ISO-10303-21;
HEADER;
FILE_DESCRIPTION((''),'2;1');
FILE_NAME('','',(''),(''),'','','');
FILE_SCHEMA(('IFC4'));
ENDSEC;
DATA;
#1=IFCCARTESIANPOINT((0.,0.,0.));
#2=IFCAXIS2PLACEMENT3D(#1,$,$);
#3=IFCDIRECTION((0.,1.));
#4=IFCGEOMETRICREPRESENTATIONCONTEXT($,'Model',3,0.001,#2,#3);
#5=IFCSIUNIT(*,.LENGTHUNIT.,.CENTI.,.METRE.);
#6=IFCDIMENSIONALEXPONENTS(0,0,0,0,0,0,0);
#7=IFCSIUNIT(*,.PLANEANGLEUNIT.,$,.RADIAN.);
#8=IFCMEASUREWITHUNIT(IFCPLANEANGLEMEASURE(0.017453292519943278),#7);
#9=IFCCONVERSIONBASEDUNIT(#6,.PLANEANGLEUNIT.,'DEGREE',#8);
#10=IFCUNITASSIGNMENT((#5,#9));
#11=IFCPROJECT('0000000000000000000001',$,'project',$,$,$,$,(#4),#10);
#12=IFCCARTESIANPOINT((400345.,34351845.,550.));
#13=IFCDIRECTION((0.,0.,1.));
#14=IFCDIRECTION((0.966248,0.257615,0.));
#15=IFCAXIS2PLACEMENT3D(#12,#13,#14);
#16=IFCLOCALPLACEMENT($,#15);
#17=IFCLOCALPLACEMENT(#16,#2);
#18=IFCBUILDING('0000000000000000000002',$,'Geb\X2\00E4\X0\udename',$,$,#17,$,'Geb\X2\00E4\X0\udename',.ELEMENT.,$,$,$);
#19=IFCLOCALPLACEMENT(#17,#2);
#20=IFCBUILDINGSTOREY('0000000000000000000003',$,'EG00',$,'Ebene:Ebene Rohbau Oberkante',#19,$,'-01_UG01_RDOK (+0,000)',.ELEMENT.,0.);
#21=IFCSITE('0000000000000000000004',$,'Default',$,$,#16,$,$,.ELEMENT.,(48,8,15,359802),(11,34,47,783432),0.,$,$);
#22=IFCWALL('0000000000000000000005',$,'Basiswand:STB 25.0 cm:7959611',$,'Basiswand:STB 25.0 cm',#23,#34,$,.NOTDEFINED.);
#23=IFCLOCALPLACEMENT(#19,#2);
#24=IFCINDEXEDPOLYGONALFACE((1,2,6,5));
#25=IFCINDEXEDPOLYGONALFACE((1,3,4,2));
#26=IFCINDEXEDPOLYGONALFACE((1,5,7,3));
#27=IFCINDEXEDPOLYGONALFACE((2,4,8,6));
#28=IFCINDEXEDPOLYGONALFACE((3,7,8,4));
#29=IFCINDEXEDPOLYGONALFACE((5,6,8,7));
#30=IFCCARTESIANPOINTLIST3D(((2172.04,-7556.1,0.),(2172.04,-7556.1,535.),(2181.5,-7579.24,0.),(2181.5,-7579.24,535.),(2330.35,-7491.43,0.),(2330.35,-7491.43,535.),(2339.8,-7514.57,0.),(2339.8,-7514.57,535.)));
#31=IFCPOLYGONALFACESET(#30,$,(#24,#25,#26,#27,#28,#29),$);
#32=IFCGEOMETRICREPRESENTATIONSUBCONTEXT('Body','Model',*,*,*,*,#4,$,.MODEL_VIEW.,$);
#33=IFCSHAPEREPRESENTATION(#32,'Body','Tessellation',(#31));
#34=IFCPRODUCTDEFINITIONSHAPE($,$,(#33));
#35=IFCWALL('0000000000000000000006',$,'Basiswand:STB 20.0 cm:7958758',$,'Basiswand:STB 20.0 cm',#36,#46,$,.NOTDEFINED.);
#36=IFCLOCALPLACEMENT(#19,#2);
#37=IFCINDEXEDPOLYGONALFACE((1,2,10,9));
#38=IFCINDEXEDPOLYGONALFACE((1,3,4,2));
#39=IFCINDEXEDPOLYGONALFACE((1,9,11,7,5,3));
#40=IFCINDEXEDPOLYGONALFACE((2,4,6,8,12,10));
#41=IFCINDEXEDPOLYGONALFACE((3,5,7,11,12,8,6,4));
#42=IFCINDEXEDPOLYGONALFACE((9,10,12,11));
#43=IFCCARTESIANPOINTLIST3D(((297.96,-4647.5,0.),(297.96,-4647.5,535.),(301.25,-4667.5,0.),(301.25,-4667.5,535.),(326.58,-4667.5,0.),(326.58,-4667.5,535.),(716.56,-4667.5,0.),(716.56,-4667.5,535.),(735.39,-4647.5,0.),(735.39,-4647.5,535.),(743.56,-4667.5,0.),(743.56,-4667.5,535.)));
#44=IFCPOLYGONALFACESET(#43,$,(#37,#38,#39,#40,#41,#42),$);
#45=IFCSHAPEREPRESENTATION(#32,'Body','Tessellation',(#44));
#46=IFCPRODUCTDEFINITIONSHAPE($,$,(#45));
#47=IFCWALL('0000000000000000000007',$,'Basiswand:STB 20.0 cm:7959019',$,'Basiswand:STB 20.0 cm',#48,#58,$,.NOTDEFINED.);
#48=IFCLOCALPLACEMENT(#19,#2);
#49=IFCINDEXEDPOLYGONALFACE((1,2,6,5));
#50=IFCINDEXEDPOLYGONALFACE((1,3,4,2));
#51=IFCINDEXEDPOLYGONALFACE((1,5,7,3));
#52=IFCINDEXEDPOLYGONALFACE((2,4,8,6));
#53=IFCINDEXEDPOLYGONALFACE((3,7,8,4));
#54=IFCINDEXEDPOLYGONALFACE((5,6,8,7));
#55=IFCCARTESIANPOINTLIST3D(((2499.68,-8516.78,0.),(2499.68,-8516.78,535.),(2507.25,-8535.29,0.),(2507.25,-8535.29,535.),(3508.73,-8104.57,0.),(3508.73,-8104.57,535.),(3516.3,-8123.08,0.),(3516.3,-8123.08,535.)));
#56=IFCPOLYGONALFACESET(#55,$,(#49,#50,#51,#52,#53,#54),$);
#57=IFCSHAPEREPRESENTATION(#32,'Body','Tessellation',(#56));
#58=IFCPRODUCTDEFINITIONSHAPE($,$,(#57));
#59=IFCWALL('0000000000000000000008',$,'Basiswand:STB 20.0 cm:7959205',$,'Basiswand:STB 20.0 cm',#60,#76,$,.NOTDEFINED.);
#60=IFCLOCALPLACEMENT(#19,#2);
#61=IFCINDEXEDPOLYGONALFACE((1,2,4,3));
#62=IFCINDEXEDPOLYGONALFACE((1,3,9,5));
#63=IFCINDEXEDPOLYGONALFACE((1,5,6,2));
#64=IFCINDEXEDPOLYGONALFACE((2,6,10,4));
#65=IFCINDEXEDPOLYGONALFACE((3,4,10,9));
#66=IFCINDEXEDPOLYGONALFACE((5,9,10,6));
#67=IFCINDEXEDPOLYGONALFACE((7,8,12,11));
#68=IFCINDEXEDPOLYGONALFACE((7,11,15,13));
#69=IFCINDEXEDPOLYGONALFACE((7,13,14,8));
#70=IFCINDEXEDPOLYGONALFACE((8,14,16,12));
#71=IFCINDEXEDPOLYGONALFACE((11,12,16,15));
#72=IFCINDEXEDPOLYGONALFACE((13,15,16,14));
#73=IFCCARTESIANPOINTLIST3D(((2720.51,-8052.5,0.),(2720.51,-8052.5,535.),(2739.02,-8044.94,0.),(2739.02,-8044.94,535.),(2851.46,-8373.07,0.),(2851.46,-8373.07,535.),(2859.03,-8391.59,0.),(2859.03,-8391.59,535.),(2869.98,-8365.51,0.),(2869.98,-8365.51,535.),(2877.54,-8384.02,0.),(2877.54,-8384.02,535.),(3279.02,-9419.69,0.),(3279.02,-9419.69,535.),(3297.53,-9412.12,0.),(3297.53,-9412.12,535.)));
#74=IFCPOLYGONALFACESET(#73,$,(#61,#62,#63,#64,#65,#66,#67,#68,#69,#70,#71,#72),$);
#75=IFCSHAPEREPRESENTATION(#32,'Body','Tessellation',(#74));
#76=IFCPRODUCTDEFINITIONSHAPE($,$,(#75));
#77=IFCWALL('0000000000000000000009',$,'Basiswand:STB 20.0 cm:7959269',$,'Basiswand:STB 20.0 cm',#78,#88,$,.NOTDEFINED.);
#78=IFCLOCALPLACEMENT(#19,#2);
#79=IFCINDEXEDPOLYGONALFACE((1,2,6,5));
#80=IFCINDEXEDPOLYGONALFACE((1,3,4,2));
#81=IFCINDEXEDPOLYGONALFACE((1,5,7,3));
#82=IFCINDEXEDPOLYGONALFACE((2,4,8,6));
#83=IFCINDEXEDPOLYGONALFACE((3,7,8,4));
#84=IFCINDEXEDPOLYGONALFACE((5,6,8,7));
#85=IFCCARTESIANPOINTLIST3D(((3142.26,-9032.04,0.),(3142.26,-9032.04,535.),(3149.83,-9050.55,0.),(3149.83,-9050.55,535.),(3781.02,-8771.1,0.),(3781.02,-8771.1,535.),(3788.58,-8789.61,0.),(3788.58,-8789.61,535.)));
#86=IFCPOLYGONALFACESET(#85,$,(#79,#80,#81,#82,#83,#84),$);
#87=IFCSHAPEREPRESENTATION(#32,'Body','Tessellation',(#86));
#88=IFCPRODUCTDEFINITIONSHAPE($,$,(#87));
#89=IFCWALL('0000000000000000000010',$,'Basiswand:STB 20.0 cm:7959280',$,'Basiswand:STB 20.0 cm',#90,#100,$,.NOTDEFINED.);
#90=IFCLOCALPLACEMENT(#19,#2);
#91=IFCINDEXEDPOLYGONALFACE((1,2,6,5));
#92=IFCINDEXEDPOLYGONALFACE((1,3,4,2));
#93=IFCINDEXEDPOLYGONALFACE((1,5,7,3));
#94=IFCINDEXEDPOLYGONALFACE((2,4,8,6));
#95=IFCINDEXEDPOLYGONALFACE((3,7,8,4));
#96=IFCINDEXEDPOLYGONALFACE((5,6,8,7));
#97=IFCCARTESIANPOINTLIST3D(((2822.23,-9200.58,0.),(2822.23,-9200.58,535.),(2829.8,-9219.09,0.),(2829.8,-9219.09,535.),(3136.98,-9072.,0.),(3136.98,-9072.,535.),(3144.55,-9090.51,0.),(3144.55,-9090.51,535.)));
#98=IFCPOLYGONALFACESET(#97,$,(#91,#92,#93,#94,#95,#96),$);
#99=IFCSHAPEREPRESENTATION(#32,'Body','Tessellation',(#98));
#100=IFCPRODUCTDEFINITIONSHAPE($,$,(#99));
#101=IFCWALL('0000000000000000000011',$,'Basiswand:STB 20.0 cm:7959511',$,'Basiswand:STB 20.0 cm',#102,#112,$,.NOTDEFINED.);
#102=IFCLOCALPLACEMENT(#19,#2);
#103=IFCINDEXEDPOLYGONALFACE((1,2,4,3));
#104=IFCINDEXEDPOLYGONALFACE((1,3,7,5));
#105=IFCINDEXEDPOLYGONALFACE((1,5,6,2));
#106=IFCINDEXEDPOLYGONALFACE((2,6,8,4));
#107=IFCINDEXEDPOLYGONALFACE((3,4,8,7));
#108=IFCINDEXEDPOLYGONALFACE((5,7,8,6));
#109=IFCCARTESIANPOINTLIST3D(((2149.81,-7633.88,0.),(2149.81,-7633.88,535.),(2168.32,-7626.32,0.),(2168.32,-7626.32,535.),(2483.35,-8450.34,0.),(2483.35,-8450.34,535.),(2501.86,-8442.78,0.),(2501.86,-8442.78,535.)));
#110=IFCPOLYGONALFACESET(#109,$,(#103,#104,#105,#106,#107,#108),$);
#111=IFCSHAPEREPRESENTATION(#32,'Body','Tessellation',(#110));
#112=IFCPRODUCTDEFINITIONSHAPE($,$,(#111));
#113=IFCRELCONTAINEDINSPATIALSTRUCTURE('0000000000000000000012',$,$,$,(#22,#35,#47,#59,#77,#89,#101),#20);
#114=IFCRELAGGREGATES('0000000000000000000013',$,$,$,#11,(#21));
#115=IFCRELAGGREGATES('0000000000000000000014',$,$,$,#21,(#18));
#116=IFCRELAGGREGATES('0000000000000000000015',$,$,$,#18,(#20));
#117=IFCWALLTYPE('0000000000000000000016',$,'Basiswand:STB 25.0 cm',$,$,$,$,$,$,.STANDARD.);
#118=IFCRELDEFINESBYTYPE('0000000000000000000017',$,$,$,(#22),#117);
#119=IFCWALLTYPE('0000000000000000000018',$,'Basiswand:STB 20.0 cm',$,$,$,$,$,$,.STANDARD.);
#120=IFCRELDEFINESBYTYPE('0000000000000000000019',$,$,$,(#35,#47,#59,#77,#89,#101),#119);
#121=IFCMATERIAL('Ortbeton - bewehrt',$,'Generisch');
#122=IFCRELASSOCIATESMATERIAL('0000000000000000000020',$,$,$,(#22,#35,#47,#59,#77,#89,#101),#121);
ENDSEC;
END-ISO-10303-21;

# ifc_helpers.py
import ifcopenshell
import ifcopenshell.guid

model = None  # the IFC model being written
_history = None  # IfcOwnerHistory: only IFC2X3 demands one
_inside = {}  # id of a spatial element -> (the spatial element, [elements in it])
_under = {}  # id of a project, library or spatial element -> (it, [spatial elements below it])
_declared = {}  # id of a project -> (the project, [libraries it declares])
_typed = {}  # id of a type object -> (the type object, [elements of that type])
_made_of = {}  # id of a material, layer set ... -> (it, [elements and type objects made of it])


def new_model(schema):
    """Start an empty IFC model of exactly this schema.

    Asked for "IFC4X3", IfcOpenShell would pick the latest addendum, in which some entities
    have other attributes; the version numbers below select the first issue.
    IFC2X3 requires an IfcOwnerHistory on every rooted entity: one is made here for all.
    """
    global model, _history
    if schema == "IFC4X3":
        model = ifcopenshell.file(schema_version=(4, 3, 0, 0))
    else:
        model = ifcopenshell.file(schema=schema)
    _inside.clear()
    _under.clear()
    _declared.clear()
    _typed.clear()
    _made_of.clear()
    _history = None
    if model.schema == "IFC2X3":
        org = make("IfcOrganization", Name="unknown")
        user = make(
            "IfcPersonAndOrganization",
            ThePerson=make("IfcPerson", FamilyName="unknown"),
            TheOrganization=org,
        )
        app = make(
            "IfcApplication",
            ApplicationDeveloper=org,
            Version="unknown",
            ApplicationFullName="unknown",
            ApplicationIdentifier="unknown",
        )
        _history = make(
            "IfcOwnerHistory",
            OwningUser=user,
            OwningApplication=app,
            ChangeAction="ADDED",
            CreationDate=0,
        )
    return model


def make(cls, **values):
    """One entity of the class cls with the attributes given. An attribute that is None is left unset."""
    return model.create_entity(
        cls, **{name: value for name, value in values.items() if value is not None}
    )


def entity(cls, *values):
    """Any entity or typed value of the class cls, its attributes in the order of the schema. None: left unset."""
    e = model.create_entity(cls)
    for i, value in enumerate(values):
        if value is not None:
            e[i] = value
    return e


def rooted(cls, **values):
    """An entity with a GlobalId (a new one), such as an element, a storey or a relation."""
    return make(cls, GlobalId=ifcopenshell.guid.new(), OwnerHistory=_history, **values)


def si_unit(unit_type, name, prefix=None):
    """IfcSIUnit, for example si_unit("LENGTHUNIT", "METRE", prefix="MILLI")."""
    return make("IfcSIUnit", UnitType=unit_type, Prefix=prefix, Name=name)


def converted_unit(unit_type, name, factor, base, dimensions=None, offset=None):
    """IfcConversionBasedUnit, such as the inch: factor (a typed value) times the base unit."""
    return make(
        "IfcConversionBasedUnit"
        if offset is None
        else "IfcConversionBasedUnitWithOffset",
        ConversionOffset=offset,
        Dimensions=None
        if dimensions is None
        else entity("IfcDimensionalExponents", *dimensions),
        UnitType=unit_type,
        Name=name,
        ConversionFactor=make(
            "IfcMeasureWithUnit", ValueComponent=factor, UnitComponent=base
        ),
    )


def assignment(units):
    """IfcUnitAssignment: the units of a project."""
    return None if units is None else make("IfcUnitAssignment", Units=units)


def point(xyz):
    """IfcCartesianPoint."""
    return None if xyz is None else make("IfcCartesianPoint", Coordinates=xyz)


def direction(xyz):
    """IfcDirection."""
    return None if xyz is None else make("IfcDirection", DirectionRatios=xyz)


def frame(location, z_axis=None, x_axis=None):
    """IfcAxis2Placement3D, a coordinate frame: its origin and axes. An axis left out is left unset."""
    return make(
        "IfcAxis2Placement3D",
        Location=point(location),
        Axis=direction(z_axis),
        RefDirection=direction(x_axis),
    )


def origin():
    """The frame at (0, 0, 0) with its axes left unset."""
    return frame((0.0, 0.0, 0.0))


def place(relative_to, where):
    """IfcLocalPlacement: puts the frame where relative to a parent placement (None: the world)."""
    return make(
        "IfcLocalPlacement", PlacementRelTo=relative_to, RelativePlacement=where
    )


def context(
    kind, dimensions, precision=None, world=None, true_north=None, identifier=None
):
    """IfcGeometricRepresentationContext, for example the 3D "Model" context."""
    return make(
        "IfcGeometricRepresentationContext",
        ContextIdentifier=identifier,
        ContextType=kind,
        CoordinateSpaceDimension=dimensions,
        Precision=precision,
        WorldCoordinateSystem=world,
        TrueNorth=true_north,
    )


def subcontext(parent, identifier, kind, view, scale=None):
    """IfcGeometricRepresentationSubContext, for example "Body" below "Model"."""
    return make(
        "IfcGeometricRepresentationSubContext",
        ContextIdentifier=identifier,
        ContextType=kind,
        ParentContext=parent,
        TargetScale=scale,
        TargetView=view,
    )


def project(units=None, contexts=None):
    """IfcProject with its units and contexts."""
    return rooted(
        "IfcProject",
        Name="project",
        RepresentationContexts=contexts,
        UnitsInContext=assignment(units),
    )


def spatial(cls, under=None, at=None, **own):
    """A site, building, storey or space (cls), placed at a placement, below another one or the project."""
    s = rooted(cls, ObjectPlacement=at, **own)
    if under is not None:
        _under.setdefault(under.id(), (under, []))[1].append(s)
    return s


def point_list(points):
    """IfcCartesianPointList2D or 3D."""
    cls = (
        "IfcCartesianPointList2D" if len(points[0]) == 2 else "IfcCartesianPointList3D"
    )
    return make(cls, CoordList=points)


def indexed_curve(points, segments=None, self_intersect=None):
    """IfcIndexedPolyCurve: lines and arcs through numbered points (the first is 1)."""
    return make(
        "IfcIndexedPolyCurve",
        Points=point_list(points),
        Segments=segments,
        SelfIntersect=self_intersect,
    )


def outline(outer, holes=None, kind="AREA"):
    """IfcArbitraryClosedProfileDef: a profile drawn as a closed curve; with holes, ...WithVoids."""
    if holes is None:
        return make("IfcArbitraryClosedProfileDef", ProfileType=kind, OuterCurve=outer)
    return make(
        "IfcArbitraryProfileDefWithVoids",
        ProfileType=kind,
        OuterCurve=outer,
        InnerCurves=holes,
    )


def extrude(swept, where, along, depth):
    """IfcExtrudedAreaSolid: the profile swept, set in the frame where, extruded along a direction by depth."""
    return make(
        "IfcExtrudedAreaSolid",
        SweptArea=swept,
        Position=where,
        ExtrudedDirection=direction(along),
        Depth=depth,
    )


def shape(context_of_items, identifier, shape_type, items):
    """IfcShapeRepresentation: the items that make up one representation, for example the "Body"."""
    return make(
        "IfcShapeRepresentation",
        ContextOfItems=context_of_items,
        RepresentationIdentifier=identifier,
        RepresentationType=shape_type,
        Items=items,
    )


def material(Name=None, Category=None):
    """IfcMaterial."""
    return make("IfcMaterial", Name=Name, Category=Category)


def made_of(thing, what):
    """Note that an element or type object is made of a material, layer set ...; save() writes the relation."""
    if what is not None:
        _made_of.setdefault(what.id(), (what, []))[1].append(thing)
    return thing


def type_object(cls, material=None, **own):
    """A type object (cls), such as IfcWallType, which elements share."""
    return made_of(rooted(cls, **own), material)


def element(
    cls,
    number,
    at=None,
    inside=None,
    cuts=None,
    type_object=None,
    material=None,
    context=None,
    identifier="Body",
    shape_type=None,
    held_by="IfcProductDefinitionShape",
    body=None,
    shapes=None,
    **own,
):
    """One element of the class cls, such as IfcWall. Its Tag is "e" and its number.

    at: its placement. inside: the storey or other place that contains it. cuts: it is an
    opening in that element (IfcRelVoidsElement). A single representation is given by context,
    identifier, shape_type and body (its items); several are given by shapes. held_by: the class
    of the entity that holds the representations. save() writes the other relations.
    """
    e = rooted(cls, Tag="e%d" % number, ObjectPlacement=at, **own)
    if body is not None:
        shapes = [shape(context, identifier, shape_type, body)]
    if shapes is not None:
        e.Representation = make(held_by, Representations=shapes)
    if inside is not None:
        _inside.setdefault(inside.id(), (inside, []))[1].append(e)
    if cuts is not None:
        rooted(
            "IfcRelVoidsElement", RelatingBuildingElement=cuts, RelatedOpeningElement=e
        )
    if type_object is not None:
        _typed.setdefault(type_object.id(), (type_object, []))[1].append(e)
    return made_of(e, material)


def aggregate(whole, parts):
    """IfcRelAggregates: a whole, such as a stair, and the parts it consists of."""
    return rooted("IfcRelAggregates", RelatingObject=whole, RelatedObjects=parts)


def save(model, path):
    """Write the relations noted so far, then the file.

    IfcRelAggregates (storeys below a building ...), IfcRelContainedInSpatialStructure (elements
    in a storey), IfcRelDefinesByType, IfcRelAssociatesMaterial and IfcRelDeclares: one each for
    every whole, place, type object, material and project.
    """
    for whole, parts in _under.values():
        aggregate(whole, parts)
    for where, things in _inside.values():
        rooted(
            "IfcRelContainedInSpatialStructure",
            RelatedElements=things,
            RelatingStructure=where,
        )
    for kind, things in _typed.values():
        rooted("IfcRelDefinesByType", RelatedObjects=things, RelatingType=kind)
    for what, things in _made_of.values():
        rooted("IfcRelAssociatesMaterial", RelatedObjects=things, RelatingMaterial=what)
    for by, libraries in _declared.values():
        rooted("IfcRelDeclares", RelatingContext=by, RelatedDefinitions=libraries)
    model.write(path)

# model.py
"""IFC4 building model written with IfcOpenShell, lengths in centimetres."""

from ifc_helpers import new_model, entity, si_unit, converted_unit, direction, frame, origin, place, context, subcontext, project, spatial, indexed_curve, outline, extrude, material, type_object, element, save


model = new_model("IFC4")

# Units and contexts
model_context = context("Model", 3, precision=0.001, world=origin(), true_north=direction((0.0, 1.0)))
body_context = subcontext(model_context, "Body", "Model", "MODEL_VIEW")
ifc_project = project(units=[si_unit("LENGTHUNIT", "METRE", prefix="CENTI"), converted_unit("PLANEANGLEUNIT", "DEGREE", entity("IfcPlaneAngleMeasure", 0.017453292519943278), si_unit("PLANEANGLEUNIT", "RADIAN"), dimensions=[0, 0, 0, 0, 0, 0, 0])], contexts=[model_context])

# Site, building, storey
site_placement = place(None, frame((400345.0, 34351845.0, 550.0), z_axis=(0.0, 0.0, 1.0), x_axis=(0.966248, 0.257615, 0.0)))
site = spatial("IfcSite", under=ifc_project, at=site_placement, Name="Default", CompositionType="ELEMENT", RefLatitude=(48, 8, 15, 359802), RefLongitude=(11, 34, 47, 783432), RefElevation=0.0)
building_placement = place(site_placement, origin())
building = spatial("IfcBuilding", under=site, at=building_placement, Name="Gebäudename", LongName="Gebäudename", CompositionType="ELEMENT")
storey_placement = place(building_placement, origin())
storey = spatial("IfcBuildingStorey", under=building, at=storey_placement, Name="EG00", ObjectType="Ebene:Ebene Rohbau Oberkante", LongName="-01_UG01_RDOK (+0,000)", CompositionType="ELEMENT", Elevation=0.0)

# Walls
ifc_material = material(Name="Ortbeton - bewehrt", Category="Generisch")
wall_type_1 = type_object("IfcWallType", Name="Basiswand:STB 25.0 cm", PredefinedType="STANDARD")
wall_1_placement = place(storey_placement, frame((2176.77, -7567.67, 0.0), z_axis=(0.0, 0.0, 1.0), x_axis=(0.925734, 0.378175, 0.0)))
element("IfcWall", 1, at=wall_1_placement, inside=storey, type_object=wall_type_1, material=ifc_material, Name="Basiswand:STB 25.0 cm:7959611", ObjectType="Basiswand:STB 25.0 cm", PredefinedType="NOTDEFINED", context=body_context, shape_type="SweptSolid", body=[
    extrude(outline(indexed_curve([(171.0, 12.5), (0.0, 12.5), (0.0, -12.5), (171.0, -12.5), (171.0, 12.5)], self_intersect=False)), origin(), (0.0, 0.0, 1.0), 535.0),
])
wall_type_2 = type_object("IfcWallType", Name="Basiswand:STB 20.0 cm", PredefinedType="STANDARD")
wall_2_placement = place(storey_placement, frame((743.56, -4657.5, 0.0), z_axis=(0.0, 0.0, 1.0), x_axis=(-1.0, 0.0, 0.0)))
element("IfcWall", 2, at=wall_2_placement, inside=storey, type_object=wall_type_2, material=ifc_material, Name="Basiswand:STB 20.0 cm:7958758", ObjectType="Basiswand:STB 20.0 cm", PredefinedType="NOTDEFINED", context=body_context, shape_type="SweptSolid", body=[
    extrude(outline(indexed_curve([(445.6, -10.0), (442.32, 10.0), (416.98, 10.0), (27.01, 10.0), (0.0, 10.0), (8.17, -10.0), (445.6, -10.0)], self_intersect=False)), origin(), (0.0, 0.0, 1.0), 535.0),
])
wall_3_placement = place(storey_placement, frame((2503.46, -8526.03, 0.0), z_axis=(0.0, 0.0, 1.0), x_axis=(0.925734, 0.378175, 0.0)))
element("IfcWall", 3, at=wall_3_placement, inside=storey, type_object=wall_type_2, material=ifc_material, Name="Basiswand:STB 20.0 cm:7959019", ObjectType="Basiswand:STB 20.0 cm", PredefinedType="NOTDEFINED", context=body_context, shape_type="SweptSolid", body=[
    extrude(outline(indexed_curve([(1090.0, 10.0), (0.0, 10.0), (0.0, -10.0), (1090.0, -10.0), (1090.0, 10.0)], self_intersect=False)), origin(), (0.0, 0.0, 1.0), 535.0),
])

# Wall, opening
wall_4_placement = place(storey_placement, frame((2729.76, -8048.72, 0.0), z_axis=(0.0, 0.0, 1.0), x_axis=(0.378175, -0.925734, 0.0)))
wall_4 = element("IfcWall", 4, at=wall_4_placement, inside=storey, type_object=wall_type_2, material=ifc_material, Name="Basiswand:STB 20.0 cm:7959205", ObjectType="Basiswand:STB 20.0 cm", PredefinedType="NOTDEFINED", context=body_context, shape_type="SweptSolid", body=[
    extrude(outline(indexed_curve([(1476.86, 10.0), (0.0, 10.0), (0.0, -10.0), (1476.86, -10.0), (1476.86, 10.0)], self_intersect=False)), origin(), (0.0, 0.0, 1.0), 535.0),
])
opening_placement = place(storey_placement, frame((2729.76, -8048.72, 0.0), z_axis=(0.0, 0.0, 1.0), x_axis=(0.378175, -0.925734, 0.0)))
element("IfcOpeningElement", 5, at=opening_placement, cuts=wall_4, PredefinedType="OPENING", context=body_context, shape_type="SweptSolid", body=[
    extrude(outline(indexed_curve([(-267.5, -10.0), (267.5, -10.0), (267.5, 10.0), (-267.5, 10.0), (-267.5, -10.0)], self_intersect=False)), frame((366.29, 0.0, 267.5), z_axis=(-1.0, 0.0, 0.0), x_axis=(0.0, 0.0, 1.0)), (0.0, 0.0, 1.0), 20.0),
])

# Walls
wall_5_placement = place(storey_placement, frame((3146.04, -9041.29, 0.0), z_axis=(0.0, 0.0, 1.0), x_axis=(0.925734, 0.378175, 0.0)))
element("IfcWall", 6, at=wall_5_placement, inside=storey, type_object=wall_type_2, material=ifc_material, Name="Basiswand:STB 20.0 cm:7959269", ObjectType="Basiswand:STB 20.0 cm", PredefinedType="NOTDEFINED", context=body_context, shape_type="SweptSolid", body=[
    extrude(outline(indexed_curve([(690.0, 10.0), (0.0, 10.0), (0.0, -10.0), (690.0, -10.0), (690.0, 10.0)], self_intersect=False)), origin(), (0.0, 0.0, 1.0), 535.0),
])
wall_6_placement = place(storey_placement, frame((2826.02, -9209.84, 0.0), z_axis=(0.0, 0.0, 1.0), x_axis=(0.925734, 0.378175, 0.0)))
element("IfcWall", 7, at=wall_6_placement, inside=storey, type_object=wall_type_2, material=ifc_material, Name="Basiswand:STB 20.0 cm:7959280", ObjectType="Basiswand:STB 20.0 cm", PredefinedType="NOTDEFINED", context=body_context, shape_type="SweptSolid", body=[
    extrude(outline(indexed_curve([(340.0, 10.0), (0.0, 10.0), (0.0, -10.0), (340.0, -10.0), (340.0, 10.0)], self_intersect=False)), origin(), (0.0, 0.0, 1.0), 535.0),
])
wall_7_placement = place(storey_placement, frame((2159.07, -7630.1, 0.0), z_axis=(0.0, 0.0, 1.0), x_axis=(0.378175, -0.925734, 0.0)))
element("IfcWall", 8, at=wall_7_placement, inside=storey, type_object=wall_type_2, material=ifc_material, Name="Basiswand:STB 20.0 cm:7959511", ObjectType="Basiswand:STB 20.0 cm", PredefinedType="NOTDEFINED", context=body_context, shape_type="SweptSolid", body=[
    extrude(outline(indexed_curve([(881.96, 10.0), (0.0, 10.0), (0.0, -10.0), (881.96, -10.0), (881.96, 10.0)], self_intersect=False)), origin(), (0.0, 0.0, 1.0), 535.0),
])

save(model, "model.ifc")
